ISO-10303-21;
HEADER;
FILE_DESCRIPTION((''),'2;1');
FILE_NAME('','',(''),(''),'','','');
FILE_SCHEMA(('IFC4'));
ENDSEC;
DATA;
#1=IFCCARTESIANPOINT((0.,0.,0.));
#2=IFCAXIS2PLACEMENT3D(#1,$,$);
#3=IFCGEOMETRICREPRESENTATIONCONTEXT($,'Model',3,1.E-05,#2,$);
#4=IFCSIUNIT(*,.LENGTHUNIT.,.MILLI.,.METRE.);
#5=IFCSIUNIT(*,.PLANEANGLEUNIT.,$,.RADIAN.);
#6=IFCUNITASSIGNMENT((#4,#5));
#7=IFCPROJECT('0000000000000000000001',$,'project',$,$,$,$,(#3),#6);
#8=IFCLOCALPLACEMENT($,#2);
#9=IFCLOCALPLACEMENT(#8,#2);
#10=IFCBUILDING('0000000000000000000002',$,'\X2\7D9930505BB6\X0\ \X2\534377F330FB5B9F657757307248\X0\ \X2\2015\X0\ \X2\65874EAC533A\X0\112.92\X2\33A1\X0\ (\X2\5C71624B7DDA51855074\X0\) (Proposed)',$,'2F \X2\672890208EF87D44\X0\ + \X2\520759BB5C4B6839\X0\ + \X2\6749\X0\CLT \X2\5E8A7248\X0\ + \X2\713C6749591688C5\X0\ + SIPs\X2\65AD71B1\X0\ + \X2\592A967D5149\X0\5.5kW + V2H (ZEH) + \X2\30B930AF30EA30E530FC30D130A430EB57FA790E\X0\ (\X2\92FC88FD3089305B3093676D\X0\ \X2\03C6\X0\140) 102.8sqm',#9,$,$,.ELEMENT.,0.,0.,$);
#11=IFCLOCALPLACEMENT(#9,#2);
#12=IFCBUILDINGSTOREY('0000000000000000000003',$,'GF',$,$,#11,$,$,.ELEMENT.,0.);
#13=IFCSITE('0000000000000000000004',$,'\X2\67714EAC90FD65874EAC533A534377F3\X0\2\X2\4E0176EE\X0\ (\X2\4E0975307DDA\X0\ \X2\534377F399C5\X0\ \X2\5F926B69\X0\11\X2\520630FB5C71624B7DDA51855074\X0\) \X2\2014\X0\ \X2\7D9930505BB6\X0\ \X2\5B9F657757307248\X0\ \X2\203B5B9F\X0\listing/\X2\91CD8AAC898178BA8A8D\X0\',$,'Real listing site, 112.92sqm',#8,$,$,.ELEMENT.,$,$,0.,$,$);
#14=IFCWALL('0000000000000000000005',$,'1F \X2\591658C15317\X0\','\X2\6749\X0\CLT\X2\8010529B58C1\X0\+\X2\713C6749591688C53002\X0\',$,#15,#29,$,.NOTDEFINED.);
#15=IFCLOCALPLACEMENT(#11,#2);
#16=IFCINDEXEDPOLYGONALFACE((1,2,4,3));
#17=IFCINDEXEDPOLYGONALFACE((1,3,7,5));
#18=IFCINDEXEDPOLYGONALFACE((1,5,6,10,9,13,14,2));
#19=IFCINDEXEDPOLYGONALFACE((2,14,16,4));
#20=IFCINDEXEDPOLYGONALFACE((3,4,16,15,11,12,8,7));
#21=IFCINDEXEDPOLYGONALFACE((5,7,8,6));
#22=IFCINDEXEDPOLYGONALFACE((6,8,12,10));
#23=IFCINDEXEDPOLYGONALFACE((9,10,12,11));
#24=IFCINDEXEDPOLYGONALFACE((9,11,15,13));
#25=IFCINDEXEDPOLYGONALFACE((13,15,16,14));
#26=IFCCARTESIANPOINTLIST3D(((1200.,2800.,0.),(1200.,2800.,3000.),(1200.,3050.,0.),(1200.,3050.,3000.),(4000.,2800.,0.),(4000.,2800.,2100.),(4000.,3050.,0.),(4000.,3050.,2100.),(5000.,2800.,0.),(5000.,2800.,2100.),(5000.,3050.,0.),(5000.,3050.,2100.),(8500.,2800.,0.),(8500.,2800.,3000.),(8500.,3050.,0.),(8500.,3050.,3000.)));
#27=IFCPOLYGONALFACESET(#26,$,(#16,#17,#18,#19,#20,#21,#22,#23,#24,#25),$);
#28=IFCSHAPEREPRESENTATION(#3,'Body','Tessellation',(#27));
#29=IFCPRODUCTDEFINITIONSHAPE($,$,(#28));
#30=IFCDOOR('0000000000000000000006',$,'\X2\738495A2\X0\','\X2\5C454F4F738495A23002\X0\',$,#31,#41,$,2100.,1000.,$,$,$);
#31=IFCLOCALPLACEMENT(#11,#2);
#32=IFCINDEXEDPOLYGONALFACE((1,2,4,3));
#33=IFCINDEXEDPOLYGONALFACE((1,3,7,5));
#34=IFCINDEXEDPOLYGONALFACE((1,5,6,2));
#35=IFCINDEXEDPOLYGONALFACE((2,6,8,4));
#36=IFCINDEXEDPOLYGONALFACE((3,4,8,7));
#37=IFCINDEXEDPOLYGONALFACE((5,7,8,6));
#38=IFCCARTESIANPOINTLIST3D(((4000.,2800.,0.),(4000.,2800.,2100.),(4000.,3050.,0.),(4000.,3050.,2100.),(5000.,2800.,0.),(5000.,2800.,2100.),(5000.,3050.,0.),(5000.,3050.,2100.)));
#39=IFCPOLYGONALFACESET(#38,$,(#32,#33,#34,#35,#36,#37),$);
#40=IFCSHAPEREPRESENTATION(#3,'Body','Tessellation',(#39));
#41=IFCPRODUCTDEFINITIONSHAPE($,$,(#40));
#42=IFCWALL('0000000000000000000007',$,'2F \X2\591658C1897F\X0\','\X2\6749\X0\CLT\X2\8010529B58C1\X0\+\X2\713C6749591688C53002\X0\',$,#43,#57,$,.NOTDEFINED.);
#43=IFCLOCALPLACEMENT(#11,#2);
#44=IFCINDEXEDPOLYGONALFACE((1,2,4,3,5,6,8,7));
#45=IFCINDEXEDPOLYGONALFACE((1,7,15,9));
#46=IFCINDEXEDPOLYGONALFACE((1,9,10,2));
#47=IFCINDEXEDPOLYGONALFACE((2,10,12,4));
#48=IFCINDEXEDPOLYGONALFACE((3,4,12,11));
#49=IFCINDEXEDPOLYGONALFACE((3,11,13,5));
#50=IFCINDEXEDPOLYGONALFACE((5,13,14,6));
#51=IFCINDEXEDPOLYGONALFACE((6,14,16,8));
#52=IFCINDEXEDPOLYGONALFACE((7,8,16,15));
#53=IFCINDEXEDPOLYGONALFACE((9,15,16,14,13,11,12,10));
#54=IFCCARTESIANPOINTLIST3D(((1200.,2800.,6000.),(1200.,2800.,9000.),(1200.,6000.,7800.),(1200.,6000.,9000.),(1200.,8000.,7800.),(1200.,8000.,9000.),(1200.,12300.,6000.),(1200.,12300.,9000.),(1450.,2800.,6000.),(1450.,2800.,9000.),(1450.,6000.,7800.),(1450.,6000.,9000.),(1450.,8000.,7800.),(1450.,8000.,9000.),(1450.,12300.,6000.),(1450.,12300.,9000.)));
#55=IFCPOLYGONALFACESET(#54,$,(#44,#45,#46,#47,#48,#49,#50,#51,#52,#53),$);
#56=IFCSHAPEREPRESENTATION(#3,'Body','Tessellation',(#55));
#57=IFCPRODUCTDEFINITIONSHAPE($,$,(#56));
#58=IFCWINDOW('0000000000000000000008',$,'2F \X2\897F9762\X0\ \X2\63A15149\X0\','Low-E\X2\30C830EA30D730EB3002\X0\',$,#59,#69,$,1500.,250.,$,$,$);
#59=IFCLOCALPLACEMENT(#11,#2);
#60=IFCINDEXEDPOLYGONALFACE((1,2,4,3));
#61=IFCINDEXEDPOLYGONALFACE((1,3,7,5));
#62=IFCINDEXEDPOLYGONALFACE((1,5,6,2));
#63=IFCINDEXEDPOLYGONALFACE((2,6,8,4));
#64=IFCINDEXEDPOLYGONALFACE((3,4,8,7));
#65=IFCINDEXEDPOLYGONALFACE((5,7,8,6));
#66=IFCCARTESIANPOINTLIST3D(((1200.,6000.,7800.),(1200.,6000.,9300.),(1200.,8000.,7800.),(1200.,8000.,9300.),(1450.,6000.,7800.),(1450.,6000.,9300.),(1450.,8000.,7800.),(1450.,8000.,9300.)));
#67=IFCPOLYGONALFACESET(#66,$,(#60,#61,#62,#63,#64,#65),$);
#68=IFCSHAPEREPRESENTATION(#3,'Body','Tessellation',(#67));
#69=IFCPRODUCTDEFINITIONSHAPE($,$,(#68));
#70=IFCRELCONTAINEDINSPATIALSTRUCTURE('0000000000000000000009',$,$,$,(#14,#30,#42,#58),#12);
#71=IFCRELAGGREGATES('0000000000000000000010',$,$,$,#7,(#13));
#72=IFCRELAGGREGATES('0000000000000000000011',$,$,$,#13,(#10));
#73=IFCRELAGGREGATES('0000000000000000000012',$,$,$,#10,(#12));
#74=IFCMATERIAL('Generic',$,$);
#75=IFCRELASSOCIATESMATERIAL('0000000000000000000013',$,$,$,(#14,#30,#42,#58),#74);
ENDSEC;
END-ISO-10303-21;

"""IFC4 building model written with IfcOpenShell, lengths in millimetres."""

from ifc_helpers import new_model, si_unit, frame, frame_2d, origin, place, context, project, spatial, rectangle, extrude, material, element, fill, save


model = new_model("IFC4")

# Units and contexts
model_context = context("Model", 3, precision=1e-05, world=origin())
ifc_project = project(units=[si_unit("LENGTHUNIT", "METRE", prefix="MILLI"), si_unit("PLANEANGLEUNIT", "RADIAN")], contexts=[model_context])

# Site, building, storey
site_placement = place(None, origin())
site = spatial("IfcSite", under=ifc_project, at=site_placement, Name="東京都文京区千石2丁目 (三田線 千石駅 徒歩11分・山手線内側) — 継ぐ家 実敷地版 ※実listing/重説要確認", ObjectType="Real listing site, 112.92sqm", CompositionType="ELEMENT", RefElevation=0.0)
building_placement = place(site_placement, origin())
building = spatial("IfcBuilding", under=site, at=building_placement, Name="継ぐ家 千石・実敷地版 ― 文京区112.92㎡ (山手線内側) (Proposed)", ObjectType="2F 木造軸組 + 切妻屋根 + 杉CLT 床版 + 焼杉外装 + SIPs断熱 + 太陽光5.5kW + V2H (ZEH) + スクリューパイル基礎 (鋼製らせん杭 φ140) 102.8sqm", CompositionType="ELEMENT", ElevationOfRefHeight=0.0, ElevationOfTerrain=0.0)
storey_placement = place(building_placement, origin())
storey = spatial("IfcBuildingStorey", under=building, at=storey_placement, Name="GF", CompositionType="ELEMENT", Elevation=0.0)

# Shared definitions
ifc_material = material(Name="Generic")

# Wall, opening, door
wall_1_placement = place(storey_placement, frame((600.0, 1400.0, 0.0)))
wall_1 = element("IfcWall", 1, at=wall_1_placement, inside=storey, material=ifc_material, Name="1F 外壁北", Description="杉CLT耐力壁+焼杉外装。", PredefinedType="NOTDEFINED", context=model_context, shape_type="SweptSolid", body=[
    extrude(rectangle(XDim=7300.0, YDim=250.0, at=frame_2d((3650.0, 125.0))), frame((600.0, 1400.0, 0.0)), (0.0, 0.0, 1.0), 3000.0),
])
opening_1_placement = place(storey_placement, frame((2000.0, 1400.0, 0.0)))
opening_1 = element("IfcOpeningElement", 2, at=opening_1_placement, cuts=wall_1, PredefinedType="NOTDEFINED", context=model_context, shape_type="SweptSolid", body=[
    extrude(rectangle(XDim=1000.0, YDim=250.0, at=frame_2d((500.0, 125.0))), frame((2000.0, 1400.0, 0.0)), (0.0, 0.0, 1.0), 2100.0),
])
door_placement = place(storey_placement, frame((2000.0, 1400.0, 0.0)))
door = element("IfcDoor", 3, at=door_placement, inside=storey, material=ifc_material, Name="玄関", Description="居住玄関。", OverallHeight=2100.0, OverallWidth=1000.0, context=model_context, shape_type="SweptSolid", body=[
    extrude(rectangle(XDim=1000.0, YDim=250.0, at=frame_2d((500.0, 125.0))), frame((2000.0, 1400.0, 0.0)), (0.0, 0.0, 1.0), 2100.0),
])
fill(opening_1, door)

# Wall, opening, window
wall_2_placement = place(storey_placement, frame((600.0, 1400.0, 3000.0)))
wall_2 = element("IfcWall", 4, at=wall_2_placement, inside=storey, material=ifc_material, Name="2F 外壁西", Description="杉CLT耐力壁+焼杉外装。", PredefinedType="NOTDEFINED", context=model_context, shape_type="SweptSolid", body=[
    extrude(rectangle(XDim=250.0, YDim=9500.0, at=frame_2d((125.0, 4750.0))), frame((600.0, 1400.0, 3000.0)), (0.0, 0.0, 1.0), 3000.0),
])
opening_2_placement = place(storey_placement, frame((600.0, 3000.0, 3900.0)))
opening_2 = element("IfcOpeningElement", 5, at=opening_2_placement, cuts=wall_2, PredefinedType="NOTDEFINED", context=model_context, shape_type="SweptSolid", body=[
    extrude(rectangle(XDim=250.0, YDim=2000.0, at=frame_2d((125.0, 1000.0))), frame((600.0, 3000.0, 3900.0)), (0.0, 0.0, 1.0), 1500.0),
])
window_placement = place(storey_placement, frame((600.0, 3000.0, 3900.0)))
window = element("IfcWindow", 6, at=window_placement, inside=storey, material=ifc_material, Name="2F 西面 採光", Description="Low-Eトリプル。", OverallHeight=1500.0, OverallWidth=250.0, context=model_context, shape_type="SweptSolid", body=[
    extrude(rectangle(XDim=250.0, YDim=2000.0, at=frame_2d((125.0, 1000.0))), frame((600.0, 3000.0, 3900.0)), (0.0, 0.0, 1.0), 1500.0),
])
fill(opening_2, window)

save(model, "model.ifc")
